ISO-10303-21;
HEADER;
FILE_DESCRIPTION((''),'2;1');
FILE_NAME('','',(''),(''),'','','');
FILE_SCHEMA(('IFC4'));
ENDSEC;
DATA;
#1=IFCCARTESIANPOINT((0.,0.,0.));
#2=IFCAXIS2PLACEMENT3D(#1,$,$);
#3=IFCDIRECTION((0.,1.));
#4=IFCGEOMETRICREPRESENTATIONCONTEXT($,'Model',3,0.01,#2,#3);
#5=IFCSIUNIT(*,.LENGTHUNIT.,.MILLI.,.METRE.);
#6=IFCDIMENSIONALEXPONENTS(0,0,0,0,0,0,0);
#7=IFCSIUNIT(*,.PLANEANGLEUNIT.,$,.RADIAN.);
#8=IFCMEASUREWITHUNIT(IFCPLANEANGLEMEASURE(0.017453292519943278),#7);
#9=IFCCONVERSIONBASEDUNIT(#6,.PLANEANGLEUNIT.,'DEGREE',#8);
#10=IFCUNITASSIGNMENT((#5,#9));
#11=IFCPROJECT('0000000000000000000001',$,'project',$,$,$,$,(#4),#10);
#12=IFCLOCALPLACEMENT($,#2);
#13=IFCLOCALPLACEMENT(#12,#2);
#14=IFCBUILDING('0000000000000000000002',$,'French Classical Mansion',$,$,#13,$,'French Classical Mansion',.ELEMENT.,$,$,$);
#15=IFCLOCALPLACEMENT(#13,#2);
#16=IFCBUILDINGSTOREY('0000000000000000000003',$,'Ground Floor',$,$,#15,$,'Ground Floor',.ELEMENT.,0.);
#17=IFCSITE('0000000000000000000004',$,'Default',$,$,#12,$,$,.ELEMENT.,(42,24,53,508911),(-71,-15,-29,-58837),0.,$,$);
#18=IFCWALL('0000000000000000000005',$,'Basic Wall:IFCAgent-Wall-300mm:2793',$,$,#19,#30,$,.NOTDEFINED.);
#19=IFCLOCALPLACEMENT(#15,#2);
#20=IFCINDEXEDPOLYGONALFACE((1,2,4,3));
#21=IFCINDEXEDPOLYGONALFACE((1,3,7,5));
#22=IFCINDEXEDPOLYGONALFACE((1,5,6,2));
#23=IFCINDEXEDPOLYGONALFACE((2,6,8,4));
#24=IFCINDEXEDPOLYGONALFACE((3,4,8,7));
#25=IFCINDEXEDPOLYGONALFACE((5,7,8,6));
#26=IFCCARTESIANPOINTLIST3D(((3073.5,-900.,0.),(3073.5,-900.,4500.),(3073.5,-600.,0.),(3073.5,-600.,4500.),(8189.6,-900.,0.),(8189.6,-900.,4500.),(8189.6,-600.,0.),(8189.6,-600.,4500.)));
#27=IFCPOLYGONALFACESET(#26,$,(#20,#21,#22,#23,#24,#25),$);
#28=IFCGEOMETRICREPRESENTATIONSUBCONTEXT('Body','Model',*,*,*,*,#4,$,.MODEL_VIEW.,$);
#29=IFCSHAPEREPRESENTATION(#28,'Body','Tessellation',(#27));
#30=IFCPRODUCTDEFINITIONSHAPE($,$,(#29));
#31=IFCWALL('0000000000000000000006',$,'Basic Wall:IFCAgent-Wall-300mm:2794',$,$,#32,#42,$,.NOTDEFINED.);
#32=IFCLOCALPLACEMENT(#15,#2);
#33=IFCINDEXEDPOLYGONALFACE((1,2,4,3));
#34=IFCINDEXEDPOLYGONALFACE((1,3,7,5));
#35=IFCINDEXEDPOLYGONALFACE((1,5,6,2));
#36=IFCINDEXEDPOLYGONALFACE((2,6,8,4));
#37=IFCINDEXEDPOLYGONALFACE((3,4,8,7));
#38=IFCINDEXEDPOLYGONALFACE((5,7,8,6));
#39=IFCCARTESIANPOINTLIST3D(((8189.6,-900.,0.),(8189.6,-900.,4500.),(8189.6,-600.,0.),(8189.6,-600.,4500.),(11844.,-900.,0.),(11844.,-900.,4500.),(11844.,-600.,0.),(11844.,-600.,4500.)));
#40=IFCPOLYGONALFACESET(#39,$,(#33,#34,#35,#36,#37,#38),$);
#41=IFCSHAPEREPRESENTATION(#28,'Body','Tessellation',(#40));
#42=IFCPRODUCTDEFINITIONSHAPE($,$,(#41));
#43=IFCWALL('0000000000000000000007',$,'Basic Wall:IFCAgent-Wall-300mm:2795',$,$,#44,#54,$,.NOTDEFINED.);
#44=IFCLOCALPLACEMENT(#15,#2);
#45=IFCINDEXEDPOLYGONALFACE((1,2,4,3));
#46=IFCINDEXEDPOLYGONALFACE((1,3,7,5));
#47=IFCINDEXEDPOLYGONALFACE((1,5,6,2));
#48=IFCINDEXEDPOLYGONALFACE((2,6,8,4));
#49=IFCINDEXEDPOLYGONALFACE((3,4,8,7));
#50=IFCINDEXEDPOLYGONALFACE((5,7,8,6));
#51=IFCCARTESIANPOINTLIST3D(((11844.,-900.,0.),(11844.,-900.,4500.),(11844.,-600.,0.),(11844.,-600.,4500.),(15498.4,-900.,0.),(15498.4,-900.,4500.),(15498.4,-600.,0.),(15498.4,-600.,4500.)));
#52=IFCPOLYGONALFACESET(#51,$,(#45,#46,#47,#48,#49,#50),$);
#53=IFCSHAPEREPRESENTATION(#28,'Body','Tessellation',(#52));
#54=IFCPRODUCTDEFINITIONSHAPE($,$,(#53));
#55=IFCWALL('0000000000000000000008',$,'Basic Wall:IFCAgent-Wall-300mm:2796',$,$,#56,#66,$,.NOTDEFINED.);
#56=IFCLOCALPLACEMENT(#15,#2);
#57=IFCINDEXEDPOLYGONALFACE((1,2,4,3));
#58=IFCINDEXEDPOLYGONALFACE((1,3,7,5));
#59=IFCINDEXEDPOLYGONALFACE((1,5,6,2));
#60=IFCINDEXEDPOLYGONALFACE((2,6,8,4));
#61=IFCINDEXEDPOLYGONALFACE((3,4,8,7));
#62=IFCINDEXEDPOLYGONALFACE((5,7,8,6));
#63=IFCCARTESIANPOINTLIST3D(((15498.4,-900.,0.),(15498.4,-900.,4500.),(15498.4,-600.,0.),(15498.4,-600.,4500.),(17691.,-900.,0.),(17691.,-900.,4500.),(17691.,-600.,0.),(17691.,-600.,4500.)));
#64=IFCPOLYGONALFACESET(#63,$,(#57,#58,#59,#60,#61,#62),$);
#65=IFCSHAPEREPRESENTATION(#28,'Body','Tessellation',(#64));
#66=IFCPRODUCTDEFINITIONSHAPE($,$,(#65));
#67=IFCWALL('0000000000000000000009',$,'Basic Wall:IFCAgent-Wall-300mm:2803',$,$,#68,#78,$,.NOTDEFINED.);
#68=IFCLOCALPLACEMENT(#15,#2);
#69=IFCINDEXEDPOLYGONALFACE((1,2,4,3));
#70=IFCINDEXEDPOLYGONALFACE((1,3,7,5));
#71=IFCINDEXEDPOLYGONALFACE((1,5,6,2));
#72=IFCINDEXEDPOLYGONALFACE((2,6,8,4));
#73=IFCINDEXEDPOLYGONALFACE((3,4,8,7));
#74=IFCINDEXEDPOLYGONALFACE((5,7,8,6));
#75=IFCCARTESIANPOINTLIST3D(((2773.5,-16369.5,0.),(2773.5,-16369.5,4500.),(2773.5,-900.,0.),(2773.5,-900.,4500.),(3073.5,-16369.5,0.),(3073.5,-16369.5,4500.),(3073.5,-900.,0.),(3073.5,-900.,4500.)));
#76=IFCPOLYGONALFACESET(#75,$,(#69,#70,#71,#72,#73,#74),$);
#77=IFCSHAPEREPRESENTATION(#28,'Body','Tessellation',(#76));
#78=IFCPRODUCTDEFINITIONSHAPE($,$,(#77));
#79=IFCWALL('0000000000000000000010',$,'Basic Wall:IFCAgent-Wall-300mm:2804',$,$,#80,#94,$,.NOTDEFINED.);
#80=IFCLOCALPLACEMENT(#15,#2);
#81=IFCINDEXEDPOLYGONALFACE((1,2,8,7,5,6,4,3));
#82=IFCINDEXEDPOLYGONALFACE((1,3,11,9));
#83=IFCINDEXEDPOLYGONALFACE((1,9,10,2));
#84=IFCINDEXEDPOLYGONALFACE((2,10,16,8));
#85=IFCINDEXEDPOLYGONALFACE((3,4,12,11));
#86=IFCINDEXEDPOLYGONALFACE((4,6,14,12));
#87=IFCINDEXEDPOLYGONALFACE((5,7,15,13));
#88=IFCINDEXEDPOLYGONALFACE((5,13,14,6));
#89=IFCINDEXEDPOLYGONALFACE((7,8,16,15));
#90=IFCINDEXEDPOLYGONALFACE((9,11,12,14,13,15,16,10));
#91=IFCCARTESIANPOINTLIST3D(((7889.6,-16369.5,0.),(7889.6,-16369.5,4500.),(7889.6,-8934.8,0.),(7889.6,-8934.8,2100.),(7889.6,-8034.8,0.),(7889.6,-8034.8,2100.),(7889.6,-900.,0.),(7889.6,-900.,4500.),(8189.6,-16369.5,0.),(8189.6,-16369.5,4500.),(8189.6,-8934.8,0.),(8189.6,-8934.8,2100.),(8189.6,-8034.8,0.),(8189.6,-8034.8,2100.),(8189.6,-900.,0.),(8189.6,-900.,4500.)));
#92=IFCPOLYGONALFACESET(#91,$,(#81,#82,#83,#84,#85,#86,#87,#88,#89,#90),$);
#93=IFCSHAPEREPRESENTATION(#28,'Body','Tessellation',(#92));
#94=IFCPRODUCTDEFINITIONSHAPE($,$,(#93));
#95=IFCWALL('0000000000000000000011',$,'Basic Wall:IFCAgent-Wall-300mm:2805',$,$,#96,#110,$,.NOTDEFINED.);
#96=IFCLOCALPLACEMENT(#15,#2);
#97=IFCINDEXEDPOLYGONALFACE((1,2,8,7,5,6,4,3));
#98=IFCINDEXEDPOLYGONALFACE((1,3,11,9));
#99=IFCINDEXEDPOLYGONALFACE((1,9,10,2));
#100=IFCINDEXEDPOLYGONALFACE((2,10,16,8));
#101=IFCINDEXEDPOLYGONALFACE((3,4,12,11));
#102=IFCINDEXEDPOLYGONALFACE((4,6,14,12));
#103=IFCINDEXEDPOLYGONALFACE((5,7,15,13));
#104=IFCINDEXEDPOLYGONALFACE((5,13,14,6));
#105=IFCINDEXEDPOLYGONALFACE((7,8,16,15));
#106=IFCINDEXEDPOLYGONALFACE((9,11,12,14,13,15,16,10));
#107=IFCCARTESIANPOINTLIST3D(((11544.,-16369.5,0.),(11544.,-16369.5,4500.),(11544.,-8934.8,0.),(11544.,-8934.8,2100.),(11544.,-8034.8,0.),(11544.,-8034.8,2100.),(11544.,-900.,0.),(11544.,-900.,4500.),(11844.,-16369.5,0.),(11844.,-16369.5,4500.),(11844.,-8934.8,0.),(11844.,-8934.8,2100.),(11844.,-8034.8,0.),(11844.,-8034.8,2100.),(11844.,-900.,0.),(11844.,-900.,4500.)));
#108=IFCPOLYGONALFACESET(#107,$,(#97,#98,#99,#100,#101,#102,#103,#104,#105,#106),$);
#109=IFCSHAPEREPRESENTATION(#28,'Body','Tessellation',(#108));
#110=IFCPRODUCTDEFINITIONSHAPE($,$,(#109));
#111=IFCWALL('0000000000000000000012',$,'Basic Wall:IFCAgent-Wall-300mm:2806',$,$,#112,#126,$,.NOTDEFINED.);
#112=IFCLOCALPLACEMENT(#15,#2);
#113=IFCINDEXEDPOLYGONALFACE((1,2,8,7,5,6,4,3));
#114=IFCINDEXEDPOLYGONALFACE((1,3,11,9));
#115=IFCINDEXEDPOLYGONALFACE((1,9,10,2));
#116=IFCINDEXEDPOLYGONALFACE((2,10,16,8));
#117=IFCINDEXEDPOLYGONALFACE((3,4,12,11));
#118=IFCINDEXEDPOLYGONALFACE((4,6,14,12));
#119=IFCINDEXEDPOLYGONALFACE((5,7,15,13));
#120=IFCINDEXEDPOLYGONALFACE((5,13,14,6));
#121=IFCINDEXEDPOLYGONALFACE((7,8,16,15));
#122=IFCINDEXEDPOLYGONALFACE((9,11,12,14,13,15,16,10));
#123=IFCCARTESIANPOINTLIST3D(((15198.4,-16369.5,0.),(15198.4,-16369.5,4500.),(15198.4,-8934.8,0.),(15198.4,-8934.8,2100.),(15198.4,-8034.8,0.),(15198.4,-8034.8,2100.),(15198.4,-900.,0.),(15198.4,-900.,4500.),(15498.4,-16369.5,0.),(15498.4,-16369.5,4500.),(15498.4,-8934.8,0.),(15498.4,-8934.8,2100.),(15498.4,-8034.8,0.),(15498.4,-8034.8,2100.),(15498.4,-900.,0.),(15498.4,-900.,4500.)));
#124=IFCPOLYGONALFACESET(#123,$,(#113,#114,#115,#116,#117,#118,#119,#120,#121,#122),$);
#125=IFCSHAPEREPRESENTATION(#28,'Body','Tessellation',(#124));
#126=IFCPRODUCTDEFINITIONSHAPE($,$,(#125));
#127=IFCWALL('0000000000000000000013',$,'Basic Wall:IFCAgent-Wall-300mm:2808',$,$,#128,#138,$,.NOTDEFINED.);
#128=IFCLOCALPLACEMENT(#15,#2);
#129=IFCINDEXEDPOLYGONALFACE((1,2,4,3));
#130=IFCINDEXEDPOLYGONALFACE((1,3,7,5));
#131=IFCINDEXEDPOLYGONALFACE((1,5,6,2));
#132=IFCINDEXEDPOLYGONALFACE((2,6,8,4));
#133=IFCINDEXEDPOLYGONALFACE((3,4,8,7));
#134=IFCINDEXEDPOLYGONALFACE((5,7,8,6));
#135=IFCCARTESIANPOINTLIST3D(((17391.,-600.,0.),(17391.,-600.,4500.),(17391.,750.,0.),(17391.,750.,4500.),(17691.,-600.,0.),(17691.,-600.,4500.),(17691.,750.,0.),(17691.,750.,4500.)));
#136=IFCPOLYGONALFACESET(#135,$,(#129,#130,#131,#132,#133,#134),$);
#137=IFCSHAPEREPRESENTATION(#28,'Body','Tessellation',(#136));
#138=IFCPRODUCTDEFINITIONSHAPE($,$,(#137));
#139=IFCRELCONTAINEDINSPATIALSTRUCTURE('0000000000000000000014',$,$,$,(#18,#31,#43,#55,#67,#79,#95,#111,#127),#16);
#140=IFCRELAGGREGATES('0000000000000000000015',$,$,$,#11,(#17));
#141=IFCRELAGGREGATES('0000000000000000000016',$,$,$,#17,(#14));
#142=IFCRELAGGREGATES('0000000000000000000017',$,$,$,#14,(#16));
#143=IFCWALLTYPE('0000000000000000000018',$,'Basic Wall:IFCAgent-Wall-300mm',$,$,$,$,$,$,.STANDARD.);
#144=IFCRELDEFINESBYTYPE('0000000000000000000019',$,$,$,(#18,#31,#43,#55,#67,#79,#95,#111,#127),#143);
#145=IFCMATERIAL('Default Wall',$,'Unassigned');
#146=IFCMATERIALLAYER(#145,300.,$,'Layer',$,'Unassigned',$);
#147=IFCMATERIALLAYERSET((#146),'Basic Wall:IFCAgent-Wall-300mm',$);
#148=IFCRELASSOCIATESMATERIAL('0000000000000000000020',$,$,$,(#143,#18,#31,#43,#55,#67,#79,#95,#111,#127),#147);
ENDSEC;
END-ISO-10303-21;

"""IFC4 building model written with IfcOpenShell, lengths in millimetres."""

from ifc_helpers import new_model, entity, si_unit, converted_unit, direction, frame, frame_2d, origin, place, context, subcontext, project, spatial, rectangle, extrude, material, layer, layer_set, layer_usage, type_object, element, save


model = new_model("IFC4")

# Units and contexts
model_context = context("Model", 3, precision=0.01, world=origin(), true_north=direction((0.0, 1.0)))
body_context = subcontext(model_context, "Body", "Model", "MODEL_VIEW")
ifc_project = project(units=[si_unit("LENGTHUNIT", "METRE", prefix="MILLI"), converted_unit("PLANEANGLEUNIT", "DEGREE", entity("IfcPlaneAngleMeasure", 0.017453292519943278), si_unit("PLANEANGLEUNIT", "RADIAN"), dimensions=[0, 0, 0, 0, 0, 0, 0])], contexts=[model_context])

# Site, building, storey
site_placement = place(None, origin())
site = spatial("IfcSite", under=ifc_project, at=site_placement, Name="Default", CompositionType="ELEMENT", RefLatitude=(42, 24, 53, 508911), RefLongitude=(-71, -15, -29, -58837), RefElevation=0.0)
building_placement = place(site_placement, origin())
building = spatial("IfcBuilding", under=site, at=building_placement, Name="French Classical Mansion", LongName="French Classical Mansion", CompositionType="ELEMENT")
storey_placement = place(building_placement, origin())
storey = spatial("IfcBuildingStorey", under=building, at=storey_placement, Name="Ground Floor", LongName="Ground Floor", CompositionType="ELEMENT", Elevation=0.0)

# Walls
ifc_material = material(Name="Default Wall", Category="Unassigned")
ifc_layer = layer(ifc_material, 300.0, Name="Layer", Category="Unassigned")
ifc_layer_set = layer_set([ifc_layer], Name="Basic Wall:IFCAgent-Wall-300mm")
ifc_layer_usage_1 = layer_usage(ifc_layer_set, "AXIS2", "NEGATIVE", 150.0)
wall_type = type_object("IfcWallType", Name="Basic Wall:IFCAgent-Wall-300mm", PredefinedType="STANDARD", material=ifc_layer_set)
wall_1_placement = place(storey_placement, frame((3073.5, -750.0, 0.0)))
element("IfcWall", 1, at=wall_1_placement, inside=storey, type_object=wall_type, material=ifc_layer_usage_1, Name="Basic Wall:IFCAgent-Wall-300mm:2793", PredefinedType="NOTDEFINED", context=body_context, shape_type="SweptSolid", body=[
    extrude(rectangle(XDim=5116.1, YDim=300.0, at=frame_2d((2558.1, 0.0), x_axis=(-1.0, 0.0))), origin(), (0.0, 0.0, 1.0), 4500.0),
])
ifc_layer_usage_2 = layer_usage(ifc_layer_set, "AXIS2", "NEGATIVE", 150.0)
wall_2_placement = place(storey_placement, frame((8189.6, -750.0, 0.0)))
element("IfcWall", 2, at=wall_2_placement, inside=storey, type_object=wall_type, material=ifc_layer_usage_2, Name="Basic Wall:IFCAgent-Wall-300mm:2794", PredefinedType="NOTDEFINED", context=body_context, shape_type="SweptSolid", body=[
    extrude(rectangle(XDim=3654.4, YDim=300.0, at=frame_2d((1827.2, 0.0), x_axis=(-1.0, 0.0))), origin(), (0.0, 0.0, 1.0), 4500.0),
])
ifc_layer_usage_3 = layer_usage(ifc_layer_set, "AXIS2", "NEGATIVE", 150.0)
wall_3_placement = place(storey_placement, frame((11844.0, -750.0, 0.0)))
element("IfcWall", 3, at=wall_3_placement, inside=storey, type_object=wall_type, material=ifc_layer_usage_3, Name="Basic Wall:IFCAgent-Wall-300mm:2795", PredefinedType="NOTDEFINED", context=body_context, shape_type="SweptSolid", body=[
    extrude(rectangle(XDim=3654.4, YDim=300.0, at=frame_2d((1827.2, 0.0), x_axis=(-1.0, 0.0))), origin(), (0.0, 0.0, 1.0), 4500.0),
])
ifc_layer_usage_4 = layer_usage(ifc_layer_set, "AXIS2", "NEGATIVE", 150.0)
wall_4_placement = place(storey_placement, frame((15498.4, -750.0, 0.0)))
element("IfcWall", 4, at=wall_4_placement, inside=storey, type_object=wall_type, material=ifc_layer_usage_4, Name="Basic Wall:IFCAgent-Wall-300mm:2796", PredefinedType="NOTDEFINED", context=body_context, shape_type="SweptSolid", body=[
    extrude(rectangle(XDim=2192.6, YDim=300.0, at=frame_2d((1096.3, 0.0), x_axis=(-1.0, 0.0))), origin(), (0.0, 0.0, 1.0), 4500.0),
])
ifc_layer_usage_5 = layer_usage(ifc_layer_set, "AXIS2", "NEGATIVE", 150.0)
wall_5_placement = place(storey_placement, frame((2923.5, -16369.5, 0.0), z_axis=(0.0, 0.0, 1.0), x_axis=(0.0, 1.0, 0.0)))
element("IfcWall", 5, at=wall_5_placement, inside=storey, type_object=wall_type, material=ifc_layer_usage_5, Name="Basic Wall:IFCAgent-Wall-300mm:2803", PredefinedType="NOTDEFINED", context=body_context, shape_type="SweptSolid", body=[
    extrude(rectangle(XDim=15469.5, YDim=300.0, at=frame_2d((7734.8, 0.0), x_axis=(-1.0, 0.0))), origin(), (0.0, 0.0, 1.0), 4500.0),
])

# Walls, openings
ifc_layer_usage_6 = layer_usage(ifc_layer_set, "AXIS2", "NEGATIVE", 150.0)
wall_6_placement = place(storey_placement, frame((8039.6, -16369.5, 0.0), z_axis=(0.0, 0.0, 1.0), x_axis=(0.0, 1.0, 0.0)))
wall_6 = element("IfcWall", 6, at=wall_6_placement, inside=storey, type_object=wall_type, material=ifc_layer_usage_6, Name="Basic Wall:IFCAgent-Wall-300mm:2804", PredefinedType="NOTDEFINED", context=body_context, shape_type="SweptSolid", body=[
    extrude(rectangle(XDim=15469.5, YDim=300.0, at=frame_2d((7734.8, 0.0), x_axis=(1.0, 0.0))), origin(), (0.0, 0.0, 1.0), 4500.0),
])
opening_1_placement = place(wall_6_placement, origin())
element("IfcOpeningElement", 7, at=opening_1_placement, cuts=wall_6, PredefinedType="OPENING", context=body_context, shape_type="SweptSolid", body=[
    extrude(rectangle(XDim=2100.0, YDim=900.0, at=frame_2d((0.0, 0.0), x_axis=(1.0, 0.0))), frame((7884.7, -150.0, 1050.0), z_axis=(0.0, 1.0, 0.0), x_axis=(0.0, 0.0, -1.0)), (0.0, 0.0, 1.0), 300.0),
])
ifc_layer_usage_7 = layer_usage(ifc_layer_set, "AXIS2", "NEGATIVE", 150.0)
wall_7_placement = place(storey_placement, frame((11694.0, -16369.5, 0.0), z_axis=(0.0, 0.0, 1.0), x_axis=(0.0, 1.0, 0.0)))
wall_7 = element("IfcWall", 8, at=wall_7_placement, inside=storey, type_object=wall_type, material=ifc_layer_usage_7, Name="Basic Wall:IFCAgent-Wall-300mm:2805", PredefinedType="NOTDEFINED", context=body_context, shape_type="SweptSolid", body=[
    extrude(rectangle(XDim=15469.5, YDim=300.0, at=frame_2d((7734.8, 0.0), x_axis=(-1.0, 0.0))), origin(), (0.0, 0.0, 1.0), 4500.0),
])
opening_2_placement = place(wall_7_placement, origin())
element("IfcOpeningElement", 9, at=opening_2_placement, cuts=wall_7, PredefinedType="OPENING", context=body_context, shape_type="SweptSolid", body=[
    extrude(rectangle(XDim=2100.0, YDim=900.0, at=frame_2d((0.0, 0.0), x_axis=(1.0, 0.0))), frame((7884.7, -150.0, 1050.0), z_axis=(0.0, 1.0, 0.0), x_axis=(0.0, 0.0, -1.0)), (0.0, 0.0, 1.0), 300.0),
])
ifc_layer_usage_8 = layer_usage(ifc_layer_set, "AXIS2", "NEGATIVE", 150.0)
wall_8_placement = place(storey_placement, frame((15348.4, -16369.5, 0.0), z_axis=(0.0, 0.0, 1.0), x_axis=(0.0, 1.0, 0.0)))
wall_8 = element("IfcWall", 10, at=wall_8_placement, inside=storey, type_object=wall_type, material=ifc_layer_usage_8, Name="Basic Wall:IFCAgent-Wall-300mm:2806", PredefinedType="NOTDEFINED", context=body_context, shape_type="SweptSolid", body=[
    extrude(rectangle(XDim=15469.5, YDim=300.0, at=frame_2d((7734.8, 0.0), x_axis=(-1.0, 0.0))), origin(), (0.0, 0.0, 1.0), 4500.0),
])
opening_3_placement = place(wall_8_placement, origin())
element("IfcOpeningElement", 11, at=opening_3_placement, cuts=wall_8, PredefinedType="OPENING", context=body_context, shape_type="SweptSolid", body=[
    extrude(rectangle(XDim=2100.0, YDim=900.0, at=frame_2d((0.0, 0.0), x_axis=(1.0, 0.0))), frame((7884.7, -150.0, 1050.0), z_axis=(0.0, 1.0, 0.0), x_axis=(0.0, 0.0, -1.0)), (0.0, 0.0, 1.0), 300.0),
])

# Wall
ifc_layer_usage_9 = layer_usage(ifc_layer_set, "AXIS2", "NEGATIVE", 150.0)
wall_9_placement = place(storey_placement, frame((17541.0, -600.0, 0.0), z_axis=(0.0, 0.0, 1.0), x_axis=(0.0, 1.0, 0.0)))
element("IfcWall", 12, at=wall_9_placement, inside=storey, type_object=wall_type, material=ifc_layer_usage_9, Name="Basic Wall:IFCAgent-Wall-300mm:2808", PredefinedType="NOTDEFINED", context=body_context, shape_type="SweptSolid", body=[
    extrude(rectangle(XDim=1350.0, YDim=300.0, at=frame_2d((675.0, 0.0), x_axis=(-1.0, 0.0))), origin(), (0.0, 0.0, 1.0), 4500.0),
])

save(model, "model.ifc")
